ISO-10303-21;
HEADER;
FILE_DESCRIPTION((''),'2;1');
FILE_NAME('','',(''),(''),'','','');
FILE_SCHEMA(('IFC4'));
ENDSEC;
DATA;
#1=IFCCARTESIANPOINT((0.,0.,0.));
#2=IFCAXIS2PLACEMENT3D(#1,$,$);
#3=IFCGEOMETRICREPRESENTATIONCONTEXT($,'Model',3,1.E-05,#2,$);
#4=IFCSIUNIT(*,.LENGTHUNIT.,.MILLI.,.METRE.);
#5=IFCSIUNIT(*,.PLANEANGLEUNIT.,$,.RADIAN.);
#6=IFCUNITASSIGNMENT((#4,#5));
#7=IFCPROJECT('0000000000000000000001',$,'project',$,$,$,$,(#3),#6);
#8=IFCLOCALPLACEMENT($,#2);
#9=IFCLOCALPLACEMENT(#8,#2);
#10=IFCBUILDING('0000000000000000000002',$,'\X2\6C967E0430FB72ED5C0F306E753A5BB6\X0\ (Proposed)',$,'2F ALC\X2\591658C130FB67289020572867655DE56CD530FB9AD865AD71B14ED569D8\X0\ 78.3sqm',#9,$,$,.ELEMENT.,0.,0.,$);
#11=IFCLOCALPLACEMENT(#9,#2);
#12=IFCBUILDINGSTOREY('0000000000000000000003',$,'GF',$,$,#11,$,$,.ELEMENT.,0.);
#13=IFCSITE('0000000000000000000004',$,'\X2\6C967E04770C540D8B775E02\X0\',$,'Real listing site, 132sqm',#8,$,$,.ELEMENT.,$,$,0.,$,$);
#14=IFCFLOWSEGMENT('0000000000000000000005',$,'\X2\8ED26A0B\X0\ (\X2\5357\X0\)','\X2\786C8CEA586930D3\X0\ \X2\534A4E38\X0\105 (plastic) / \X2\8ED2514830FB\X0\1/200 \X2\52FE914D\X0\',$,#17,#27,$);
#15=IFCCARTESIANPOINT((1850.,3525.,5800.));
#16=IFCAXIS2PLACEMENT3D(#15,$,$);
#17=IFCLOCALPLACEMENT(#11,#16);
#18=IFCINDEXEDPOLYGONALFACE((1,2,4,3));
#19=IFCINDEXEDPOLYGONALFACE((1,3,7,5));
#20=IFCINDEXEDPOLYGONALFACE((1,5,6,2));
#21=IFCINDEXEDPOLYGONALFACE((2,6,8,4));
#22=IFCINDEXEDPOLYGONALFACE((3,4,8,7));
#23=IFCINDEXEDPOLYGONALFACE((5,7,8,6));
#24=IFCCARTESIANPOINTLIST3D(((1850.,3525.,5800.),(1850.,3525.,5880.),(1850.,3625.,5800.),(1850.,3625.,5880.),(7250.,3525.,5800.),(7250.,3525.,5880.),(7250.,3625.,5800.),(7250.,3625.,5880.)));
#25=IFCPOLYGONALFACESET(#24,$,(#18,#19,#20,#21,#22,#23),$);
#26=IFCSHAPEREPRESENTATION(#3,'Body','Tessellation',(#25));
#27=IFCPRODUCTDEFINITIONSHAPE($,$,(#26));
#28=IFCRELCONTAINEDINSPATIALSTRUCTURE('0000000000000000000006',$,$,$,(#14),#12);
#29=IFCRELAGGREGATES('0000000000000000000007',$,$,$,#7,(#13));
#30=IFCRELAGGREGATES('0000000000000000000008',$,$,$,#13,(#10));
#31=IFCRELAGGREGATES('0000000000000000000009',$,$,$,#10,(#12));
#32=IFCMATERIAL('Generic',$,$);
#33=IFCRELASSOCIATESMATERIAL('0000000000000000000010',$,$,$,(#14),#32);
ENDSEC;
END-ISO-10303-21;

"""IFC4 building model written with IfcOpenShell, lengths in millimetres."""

from ifc_helpers import new_model, si_unit, frame, frame_2d, origin, place, context, project, spatial, rectangle, extrude, material, element, save


model = new_model("IFC4")

# Units and contexts
model_context = context("Model", 3, precision=1e-05, world=origin())
ifc_project = project(units=[si_unit("LENGTHUNIT", "METRE", prefix="MILLI"), si_unit("PLANEANGLEUNIT", "RADIAN")], contexts=[model_context])

# Site, building, storey
site_placement = place(None, origin())
site = spatial("IfcSite", under=ifc_project, at=site_placement, Name="沖縄県名護市", ObjectType="Real listing site, 132sqm", CompositionType="ELEMENT", RefElevation=0.0)
building_placement = place(site_placement, origin())
building = spatial("IfcBuilding", under=site, at=building_placement, Name="沖縄・狭小の町家 (Proposed)", ObjectType="2F ALC外壁・木造在来工法・高断熱仕様 78.3sqm", CompositionType="ELEMENT", ElevationOfRefHeight=0.0, ElevationOfTerrain=0.0)
storey_placement = place(building_placement, origin())
storey = spatial("IfcBuildingStorey", under=building, at=storey_placement, Name="GF", CompositionType="ELEMENT", Elevation=0.0)

# Flow segment
ifc_material_1 = material(Name="Generic")
flow_segment_placement = place(storey_placement, frame((1850.0, 3525.0, 5800.0)))
element("IfcFlowSegment", 1, at=flow_segment_placement, inside=storey, material=ifc_material_1, Name="軒樋 (南)", Description="硬質塩ビ 半丸105 (plastic) / 軒先・1/200 勾配", context=model_context, shape_type="SweptSolid", body=[
    extrude(rectangle(XDim=5400.0, YDim=100.0, at=frame_2d((2700.0, 50.0))), frame((1850.0, 3525.0, 5800.0)), (0.0, 0.0, 1.0), 80.0),
])

save(model, "model.ifc")
